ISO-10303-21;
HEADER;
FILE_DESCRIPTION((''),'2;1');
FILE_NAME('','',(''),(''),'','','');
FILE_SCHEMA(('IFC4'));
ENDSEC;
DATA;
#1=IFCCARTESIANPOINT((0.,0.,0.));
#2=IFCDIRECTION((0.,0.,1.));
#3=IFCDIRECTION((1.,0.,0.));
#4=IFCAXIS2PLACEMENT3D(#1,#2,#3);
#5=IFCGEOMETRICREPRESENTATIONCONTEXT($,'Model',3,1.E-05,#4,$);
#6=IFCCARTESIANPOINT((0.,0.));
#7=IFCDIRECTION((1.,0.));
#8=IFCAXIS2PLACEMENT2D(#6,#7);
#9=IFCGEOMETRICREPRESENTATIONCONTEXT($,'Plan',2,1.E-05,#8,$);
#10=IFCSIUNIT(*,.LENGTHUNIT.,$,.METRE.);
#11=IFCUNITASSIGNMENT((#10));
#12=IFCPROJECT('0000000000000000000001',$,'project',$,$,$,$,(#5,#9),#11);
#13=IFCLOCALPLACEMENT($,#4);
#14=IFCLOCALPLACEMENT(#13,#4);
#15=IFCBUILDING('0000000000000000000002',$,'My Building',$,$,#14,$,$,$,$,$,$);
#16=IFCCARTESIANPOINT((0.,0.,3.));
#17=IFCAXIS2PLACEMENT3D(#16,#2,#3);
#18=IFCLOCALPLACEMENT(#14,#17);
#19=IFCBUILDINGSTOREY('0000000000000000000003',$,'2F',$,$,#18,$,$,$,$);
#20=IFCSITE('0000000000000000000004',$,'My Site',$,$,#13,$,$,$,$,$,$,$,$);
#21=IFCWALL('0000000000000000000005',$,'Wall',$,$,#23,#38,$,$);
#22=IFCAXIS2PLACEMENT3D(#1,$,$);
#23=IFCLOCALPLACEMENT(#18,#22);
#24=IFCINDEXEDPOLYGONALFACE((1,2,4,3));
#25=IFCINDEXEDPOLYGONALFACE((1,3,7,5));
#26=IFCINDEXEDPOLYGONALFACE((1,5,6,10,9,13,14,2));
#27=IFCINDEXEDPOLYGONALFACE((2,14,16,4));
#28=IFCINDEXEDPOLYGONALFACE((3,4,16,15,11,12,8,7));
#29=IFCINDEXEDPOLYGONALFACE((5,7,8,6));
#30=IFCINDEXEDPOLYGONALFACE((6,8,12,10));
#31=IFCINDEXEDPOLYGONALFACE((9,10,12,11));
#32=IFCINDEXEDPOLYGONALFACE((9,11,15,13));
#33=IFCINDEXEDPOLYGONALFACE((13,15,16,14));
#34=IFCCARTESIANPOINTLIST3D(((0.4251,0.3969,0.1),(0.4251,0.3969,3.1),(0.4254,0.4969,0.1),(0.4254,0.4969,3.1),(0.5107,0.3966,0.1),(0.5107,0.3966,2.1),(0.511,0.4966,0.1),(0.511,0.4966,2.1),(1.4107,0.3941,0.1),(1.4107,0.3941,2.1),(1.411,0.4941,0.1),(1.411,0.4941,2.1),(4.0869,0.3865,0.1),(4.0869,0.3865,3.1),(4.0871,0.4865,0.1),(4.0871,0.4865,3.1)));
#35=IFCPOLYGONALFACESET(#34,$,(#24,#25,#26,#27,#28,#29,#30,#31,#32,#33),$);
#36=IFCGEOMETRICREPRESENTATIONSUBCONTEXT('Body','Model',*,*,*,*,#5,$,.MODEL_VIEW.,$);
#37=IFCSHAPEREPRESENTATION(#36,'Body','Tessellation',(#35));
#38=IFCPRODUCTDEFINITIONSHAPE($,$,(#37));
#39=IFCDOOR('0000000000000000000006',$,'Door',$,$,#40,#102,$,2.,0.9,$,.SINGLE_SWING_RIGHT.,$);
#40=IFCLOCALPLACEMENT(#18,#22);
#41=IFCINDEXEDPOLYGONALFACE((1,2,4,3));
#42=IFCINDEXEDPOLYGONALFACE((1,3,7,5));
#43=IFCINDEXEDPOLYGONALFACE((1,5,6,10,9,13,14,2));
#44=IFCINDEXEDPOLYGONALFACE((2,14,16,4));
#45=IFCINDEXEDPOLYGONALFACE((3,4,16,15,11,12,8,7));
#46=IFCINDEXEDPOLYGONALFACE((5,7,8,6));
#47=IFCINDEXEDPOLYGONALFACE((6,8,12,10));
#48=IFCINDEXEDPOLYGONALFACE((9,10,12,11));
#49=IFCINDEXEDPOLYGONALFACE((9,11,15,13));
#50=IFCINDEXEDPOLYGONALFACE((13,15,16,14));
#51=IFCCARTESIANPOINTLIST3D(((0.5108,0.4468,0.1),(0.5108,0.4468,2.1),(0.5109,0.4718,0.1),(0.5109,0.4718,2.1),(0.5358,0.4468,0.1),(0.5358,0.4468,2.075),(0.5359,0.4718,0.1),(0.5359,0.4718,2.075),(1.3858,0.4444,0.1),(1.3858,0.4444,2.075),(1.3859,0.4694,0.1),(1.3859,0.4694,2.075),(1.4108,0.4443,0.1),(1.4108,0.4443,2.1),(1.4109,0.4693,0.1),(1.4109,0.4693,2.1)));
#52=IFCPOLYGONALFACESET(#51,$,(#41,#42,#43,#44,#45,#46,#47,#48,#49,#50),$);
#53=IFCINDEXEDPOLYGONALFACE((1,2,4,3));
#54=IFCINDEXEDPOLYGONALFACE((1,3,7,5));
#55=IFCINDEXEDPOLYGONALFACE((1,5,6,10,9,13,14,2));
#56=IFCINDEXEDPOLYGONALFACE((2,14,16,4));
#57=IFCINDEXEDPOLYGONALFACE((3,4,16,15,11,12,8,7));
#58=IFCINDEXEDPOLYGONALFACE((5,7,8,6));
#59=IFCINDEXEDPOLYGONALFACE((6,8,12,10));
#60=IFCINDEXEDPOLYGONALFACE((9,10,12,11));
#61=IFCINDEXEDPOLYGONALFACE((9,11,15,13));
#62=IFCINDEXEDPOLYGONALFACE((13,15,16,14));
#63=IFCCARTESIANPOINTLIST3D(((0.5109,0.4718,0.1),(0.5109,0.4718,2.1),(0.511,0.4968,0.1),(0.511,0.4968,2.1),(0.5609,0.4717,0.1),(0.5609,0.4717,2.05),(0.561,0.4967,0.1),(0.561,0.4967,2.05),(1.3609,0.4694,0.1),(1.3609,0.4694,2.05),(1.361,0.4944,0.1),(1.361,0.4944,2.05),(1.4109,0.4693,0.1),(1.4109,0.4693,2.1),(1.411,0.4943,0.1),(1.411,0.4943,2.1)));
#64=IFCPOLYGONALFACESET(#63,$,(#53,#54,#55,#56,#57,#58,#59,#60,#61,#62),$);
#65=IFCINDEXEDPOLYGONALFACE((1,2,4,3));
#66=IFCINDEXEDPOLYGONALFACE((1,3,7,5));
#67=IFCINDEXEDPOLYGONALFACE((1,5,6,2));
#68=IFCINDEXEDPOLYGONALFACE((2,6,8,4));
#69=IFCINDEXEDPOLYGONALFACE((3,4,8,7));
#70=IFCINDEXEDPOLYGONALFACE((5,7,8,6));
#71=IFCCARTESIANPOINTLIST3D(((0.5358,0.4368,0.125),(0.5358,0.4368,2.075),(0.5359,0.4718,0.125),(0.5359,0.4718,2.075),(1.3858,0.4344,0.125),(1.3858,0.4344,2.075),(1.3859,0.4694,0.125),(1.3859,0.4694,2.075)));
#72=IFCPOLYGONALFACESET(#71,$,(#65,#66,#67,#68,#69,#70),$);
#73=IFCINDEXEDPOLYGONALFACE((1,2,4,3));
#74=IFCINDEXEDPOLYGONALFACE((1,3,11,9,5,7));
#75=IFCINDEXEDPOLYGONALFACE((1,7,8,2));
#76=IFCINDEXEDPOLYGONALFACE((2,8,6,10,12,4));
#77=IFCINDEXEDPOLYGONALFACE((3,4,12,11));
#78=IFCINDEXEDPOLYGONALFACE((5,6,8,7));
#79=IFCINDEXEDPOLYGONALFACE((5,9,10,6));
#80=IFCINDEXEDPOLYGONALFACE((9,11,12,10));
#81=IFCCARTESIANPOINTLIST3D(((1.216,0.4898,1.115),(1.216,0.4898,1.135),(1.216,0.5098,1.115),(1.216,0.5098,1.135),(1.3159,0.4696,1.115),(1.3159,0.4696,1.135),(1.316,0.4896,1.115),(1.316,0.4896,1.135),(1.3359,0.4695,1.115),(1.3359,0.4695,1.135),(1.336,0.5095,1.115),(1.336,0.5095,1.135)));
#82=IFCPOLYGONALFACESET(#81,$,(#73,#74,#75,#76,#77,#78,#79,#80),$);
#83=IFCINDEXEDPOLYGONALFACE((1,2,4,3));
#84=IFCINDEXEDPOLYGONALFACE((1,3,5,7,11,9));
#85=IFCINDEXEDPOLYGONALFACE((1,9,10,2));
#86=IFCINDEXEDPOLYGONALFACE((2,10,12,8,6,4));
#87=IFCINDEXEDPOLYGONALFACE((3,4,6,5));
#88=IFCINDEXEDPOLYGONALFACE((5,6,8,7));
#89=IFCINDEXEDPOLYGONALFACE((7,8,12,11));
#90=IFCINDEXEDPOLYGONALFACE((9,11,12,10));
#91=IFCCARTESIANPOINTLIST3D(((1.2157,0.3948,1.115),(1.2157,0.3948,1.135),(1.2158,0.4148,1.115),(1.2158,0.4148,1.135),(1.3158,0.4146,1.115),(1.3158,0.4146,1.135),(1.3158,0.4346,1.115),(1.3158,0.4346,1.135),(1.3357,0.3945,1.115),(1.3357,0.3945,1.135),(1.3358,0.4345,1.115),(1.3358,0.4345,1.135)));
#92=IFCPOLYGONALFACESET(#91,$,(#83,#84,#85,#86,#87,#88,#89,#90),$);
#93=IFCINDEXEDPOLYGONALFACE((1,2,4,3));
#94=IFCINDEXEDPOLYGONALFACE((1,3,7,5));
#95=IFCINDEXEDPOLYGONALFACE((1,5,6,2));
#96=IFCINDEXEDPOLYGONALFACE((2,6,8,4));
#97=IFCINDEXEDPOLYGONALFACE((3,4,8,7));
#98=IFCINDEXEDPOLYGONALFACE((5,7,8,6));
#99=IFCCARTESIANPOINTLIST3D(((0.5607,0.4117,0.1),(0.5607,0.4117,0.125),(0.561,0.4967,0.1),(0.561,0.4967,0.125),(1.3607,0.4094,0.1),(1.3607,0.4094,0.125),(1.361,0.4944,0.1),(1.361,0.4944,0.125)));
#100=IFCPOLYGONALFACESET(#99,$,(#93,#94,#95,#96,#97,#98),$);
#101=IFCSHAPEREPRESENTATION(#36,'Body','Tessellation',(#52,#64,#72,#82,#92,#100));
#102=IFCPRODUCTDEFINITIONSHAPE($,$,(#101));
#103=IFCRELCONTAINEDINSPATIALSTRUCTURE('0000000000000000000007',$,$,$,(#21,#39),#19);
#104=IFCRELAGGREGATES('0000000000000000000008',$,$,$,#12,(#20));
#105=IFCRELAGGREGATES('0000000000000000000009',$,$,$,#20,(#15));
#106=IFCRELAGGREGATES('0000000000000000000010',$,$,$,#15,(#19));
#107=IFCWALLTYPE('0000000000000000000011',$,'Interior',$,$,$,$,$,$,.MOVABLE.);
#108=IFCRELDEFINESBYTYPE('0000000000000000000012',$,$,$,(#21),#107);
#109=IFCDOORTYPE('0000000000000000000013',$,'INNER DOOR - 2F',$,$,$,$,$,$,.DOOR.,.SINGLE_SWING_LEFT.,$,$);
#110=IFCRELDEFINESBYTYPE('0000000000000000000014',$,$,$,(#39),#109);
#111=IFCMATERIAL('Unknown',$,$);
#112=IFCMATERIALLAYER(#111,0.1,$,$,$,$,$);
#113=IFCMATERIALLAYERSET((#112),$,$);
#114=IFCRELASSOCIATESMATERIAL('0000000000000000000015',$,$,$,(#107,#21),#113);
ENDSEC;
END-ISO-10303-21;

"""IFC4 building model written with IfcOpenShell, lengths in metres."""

from ifc_helpers import new_model, entity, si_unit, frame, origin_with_axes, origin_2d_with_axis, place, context, subcontext, project, spatial, line, indexed_curve, outline, extrude, shape, source, transform, mapped, material, layer, layer_set, layer_usage, type_object, type_shapes, element, fill, save


model = new_model("IFC4")

# Units and contexts
model_context = context("Model", 3, precision=1e-05, world=origin_with_axes())
plan_context = context("Plan", 2, precision=1e-05, world=origin_2d_with_axis())
body_context_1 = subcontext(model_context, "Body", "Model", "MODEL_VIEW")
body_context_2 = subcontext(plan_context, "Body", "Plan", "PLAN_VIEW")
ifc_project = project(units=[si_unit("LENGTHUNIT", "METRE")], contexts=[model_context, plan_context])

# Site, building, storey
site_placement = place(None, origin_with_axes())
site = spatial("IfcSite", under=ifc_project, at=site_placement, Name="My Site")
building_placement = place(site_placement, origin_with_axes())
building = spatial("IfcBuilding", under=site, at=building_placement, Name="My Building")
storey_placement = place(building_placement, frame((0.0, 0.0, 3.0), z_axis=(0.0, 0.0, 1.0), x_axis=(1.0, 0.0, 0.0)))
storey = spatial("IfcBuildingStorey", under=building, at=storey_placement, Name="2F")

# Shared definitions
ifc_material = material(Name="Unknown")

# Shared definitions
ifc_layer_1 = layer(ifc_material, 0.1)
ifc_layer_set_1 = layer_set([ifc_layer_1])
wall_type_1 = type_object("IfcWallType", Name="Interior", PredefinedType="MOVABLE", material=ifc_layer_set_1)
shared_shape_1 = source(origin_with_axes(), body_context_1, "Body", "SweptSolid", [
    extrude(outline(indexed_curve([(0.0, 0.0), (0.9, 0.0), (0.9, 2.0), (0.0, 2.0)], segments=[line(1, 2, 3, 4, 1)])), frame((0.0, -0.6, 0.0), z_axis=(0.0, -1.0, 0.0), x_axis=(1.0, 0.0, 0.0)), (0.0, 0.0, -1.0), 1.2),
])
door_type_1 = type_object("IfcDoorType", Name="INNER DOOR - 2F", OperationType="SINGLE_SWING_LEFT", PredefinedType="DOOR")
shared_shape_2 = source(origin_with_axes(), body_context_1, "Body", "SweptSolid", [
    extrude(outline(indexed_curve([(0.0, 0.0), (0.0, 2.0), (0.9, 2.0), (0.9, 0.0), (0.875, 0.0), (0.875, 1.975), (0.025, 1.975), (0.025, 0.0)], segments=[line(1, 2, 3, 4, 5, 6, 7, 8, 1)])), frame((0.0, 0.025, 0.0), z_axis=(0.0, -1.0, 0.0), x_axis=(1.0, 0.0, 0.0)), (0.0, 0.0, -1.0), 0.025),
    extrude(outline(indexed_curve([(0.0, 0.0), (0.0, 2.0), (0.9, 2.0), (0.9, 0.0), (0.85, 0.0), (0.85, 1.95), (0.05, 1.95), (0.05, 0.0)], segments=[line(1, 2, 3, 4, 5, 6, 7, 8, 1)])), frame((0.0, 0.0, 0.0), z_axis=(0.0, -1.0, 0.0), x_axis=(1.0, 0.0, 0.0)), (0.0, 0.0, -1.0), 0.025),
    extrude(outline(indexed_curve([(0.0, 0.0), (0.85, 0.0), (0.85, 0.035), (0.0, 0.035)], segments=[line(1, 2, 3, 4, 1)])), frame((0.025, 0.025, 0.025), z_axis=(0.0, 0.0, 1.0), x_axis=(1.0, 0.0, 0.0)), (0.0, 0.0, 1.0), 1.95),
    extrude(outline(indexed_curve([(0.0, 0.0), (0.0, -0.04), (0.12, -0.04), (0.12, -0.02), (0.02, -0.02), (0.02, 0.0)], segments=[line(1, 2, 3, 4, 5, 6, 1)])), frame((0.075, 0.025, 1.015), z_axis=(0.0, 0.0, 1.0), x_axis=(1.0, 0.0, 0.0)), (0.0, 0.0, 1.0), 0.02),
    extrude(outline(indexed_curve([(0.0, 0.0), (0.0, 0.04), (0.12, 0.04), (0.12, 0.02), (0.02, 0.02), (0.02, 0.0)], segments=[line(1, 2, 3, 4, 5, 6, 1)])), frame((0.075, 0.06, 1.015), z_axis=(0.0, 0.0, 1.0), x_axis=(1.0, 0.0, 0.0)), (0.0, 0.0, 1.0), 0.02),
    extrude(outline(indexed_curve([(0.0, 0.0), (0.8, 0.0), (0.8, 0.085), (0.0, 0.085)], segments=[line(1, 2, 3, 4, 1)])), frame((0.05, 0.0, 0.0), z_axis=(0.0, 0.0, 1.0), x_axis=(1.0, 0.0, 0.0)), (0.0, 0.0, 1.0), 0.025),
])
shared_shape_3 = source(origin_with_axes(), body_context_2, "Body", "Curve2D", [
    entity("IfcIndexedPolyCurve", entity("IfcCartesianPointList2D", [[0.0, 0.0], [0.0, 0.05], [0.025, 0.05], [0.025, 0.025], [0.05, 0.025], [0.05, 0.0]]), [entity("IfcLineIndex", [1, 2, 3, 4, 5, 6, 1])]),
    entity("IfcIndexedPolyCurve", entity("IfcCartesianPointList2D", [[0.9, 0.0], [0.9, 0.05], [0.875, 0.05], [0.875, 0.025], [0.85, 0.025], [0.85, 0.0]]), [entity("IfcLineIndex", [1, 2, 3, 4, 5, 6, 1])]),
    entity("IfcTrimmedCurve", entity("IfcEllipse", entity("IfcAxis2Placement2D", entity("IfcCartesianPoint", [0.84, 0.05]), entity("IfcDirection", [1.0, 0.0])), 0.815, 0.85), [entity("IfcCartesianPoint", [0.84, 0.9])], [entity("IfcCartesianPoint", [0.025, 0.05])], True, "CARTESIAN"),
    entity("IfcIndexedPolyCurve", entity("IfcCartesianPointList2D", [[0.875, 0.05], [0.84, 0.05], [0.84, 0.9], [0.875, 0.9]]), [entity("IfcLineIndex", [1, 2, 3, 4, 1])]),
])
type_shapes(door_type_1, [shared_shape_2, shared_shape_3])

# Wall, opening, door
ifc_layer_usage_1 = layer_usage(ifc_layer_set_1, "AXIS2", "POSITIVE", 0.0)
wall_1_placement = place(storey_placement, frame((0.4251, 0.3969, 0.1), z_axis=(0.0, 0.0, 1.0), x_axis=(0.999996, -0.002846, 0.0)))
wall_1 = element("IfcWall", 1, at=wall_1_placement, inside=storey, type_object=wall_type_1, material=ifc_layer_usage_1, Name="Wall", context=body_context_1, shape_type="SweptSolid", body=[
    extrude(outline(indexed_curve([(0.0, 0.0), (0.0, 0.1), (3.6618, 0.1), (3.6618, 0.0)], segments=[line(1, 2, 3, 4, 1)])), origin_with_axes(), (0.0, 0.0, 1.0), 3.0),
])
opening_1_placement = place(wall_1_placement, frame((0.9856, 0.1002, 0.0), z_axis=(0.0, 0.0, 1.0), x_axis=(-1.0, 0.0, 0.0)))
opening_1 = element("IfcOpeningElement", 2, at=opening_1_placement, cuts=wall_1, PredefinedType="OPENING", context=body_context_1, shape_type="MappedRepresentation", body=[
    mapped(shared_shape_1, transform((0.0, 0.0, 0.0), x_axis=(1.0, 0.0, 0.0), y_axis=(0.0, 1.0, 0.0), z_axis=(0.0, 0.0, 1.0), scale=1.0)),
])
door_1_placement = place(opening_1_placement, frame((0.0, 0.0, 0.0), z_axis=(0.0, 0.0, 1.0), x_axis=(1.0, 0.0, 0.0)))
door_1 = element("IfcDoor", 3, at=door_1_placement, inside=storey, type_object=door_type_1, Name="Door", OperationType="SINGLE_SWING_RIGHT", OverallHeight=2.0, OverallWidth=0.9, shapes=[
    shape(body_context_1, "Body", "MappedRepresentation", [mapped(shared_shape_2, transform((0.0, 0.0, 0.0), x_axis=(1.0, 0.0, 0.0), y_axis=(0.0, 1.0, 0.0), z_axis=(0.0, 0.0, 1.0), scale=1.0))]),
    shape(body_context_2, "Body", "MappedRepresentation", [mapped(shared_shape_3, transform((0.0, 0.0, 0.0), x_axis=(1.0, 0.0, 0.0), y_axis=(0.0, 1.0, 0.0), z_axis=(0.0, 0.0, 1.0), scale=1.0))]),
])
fill(opening_1, door_1)

save(model, "model.ifc")
